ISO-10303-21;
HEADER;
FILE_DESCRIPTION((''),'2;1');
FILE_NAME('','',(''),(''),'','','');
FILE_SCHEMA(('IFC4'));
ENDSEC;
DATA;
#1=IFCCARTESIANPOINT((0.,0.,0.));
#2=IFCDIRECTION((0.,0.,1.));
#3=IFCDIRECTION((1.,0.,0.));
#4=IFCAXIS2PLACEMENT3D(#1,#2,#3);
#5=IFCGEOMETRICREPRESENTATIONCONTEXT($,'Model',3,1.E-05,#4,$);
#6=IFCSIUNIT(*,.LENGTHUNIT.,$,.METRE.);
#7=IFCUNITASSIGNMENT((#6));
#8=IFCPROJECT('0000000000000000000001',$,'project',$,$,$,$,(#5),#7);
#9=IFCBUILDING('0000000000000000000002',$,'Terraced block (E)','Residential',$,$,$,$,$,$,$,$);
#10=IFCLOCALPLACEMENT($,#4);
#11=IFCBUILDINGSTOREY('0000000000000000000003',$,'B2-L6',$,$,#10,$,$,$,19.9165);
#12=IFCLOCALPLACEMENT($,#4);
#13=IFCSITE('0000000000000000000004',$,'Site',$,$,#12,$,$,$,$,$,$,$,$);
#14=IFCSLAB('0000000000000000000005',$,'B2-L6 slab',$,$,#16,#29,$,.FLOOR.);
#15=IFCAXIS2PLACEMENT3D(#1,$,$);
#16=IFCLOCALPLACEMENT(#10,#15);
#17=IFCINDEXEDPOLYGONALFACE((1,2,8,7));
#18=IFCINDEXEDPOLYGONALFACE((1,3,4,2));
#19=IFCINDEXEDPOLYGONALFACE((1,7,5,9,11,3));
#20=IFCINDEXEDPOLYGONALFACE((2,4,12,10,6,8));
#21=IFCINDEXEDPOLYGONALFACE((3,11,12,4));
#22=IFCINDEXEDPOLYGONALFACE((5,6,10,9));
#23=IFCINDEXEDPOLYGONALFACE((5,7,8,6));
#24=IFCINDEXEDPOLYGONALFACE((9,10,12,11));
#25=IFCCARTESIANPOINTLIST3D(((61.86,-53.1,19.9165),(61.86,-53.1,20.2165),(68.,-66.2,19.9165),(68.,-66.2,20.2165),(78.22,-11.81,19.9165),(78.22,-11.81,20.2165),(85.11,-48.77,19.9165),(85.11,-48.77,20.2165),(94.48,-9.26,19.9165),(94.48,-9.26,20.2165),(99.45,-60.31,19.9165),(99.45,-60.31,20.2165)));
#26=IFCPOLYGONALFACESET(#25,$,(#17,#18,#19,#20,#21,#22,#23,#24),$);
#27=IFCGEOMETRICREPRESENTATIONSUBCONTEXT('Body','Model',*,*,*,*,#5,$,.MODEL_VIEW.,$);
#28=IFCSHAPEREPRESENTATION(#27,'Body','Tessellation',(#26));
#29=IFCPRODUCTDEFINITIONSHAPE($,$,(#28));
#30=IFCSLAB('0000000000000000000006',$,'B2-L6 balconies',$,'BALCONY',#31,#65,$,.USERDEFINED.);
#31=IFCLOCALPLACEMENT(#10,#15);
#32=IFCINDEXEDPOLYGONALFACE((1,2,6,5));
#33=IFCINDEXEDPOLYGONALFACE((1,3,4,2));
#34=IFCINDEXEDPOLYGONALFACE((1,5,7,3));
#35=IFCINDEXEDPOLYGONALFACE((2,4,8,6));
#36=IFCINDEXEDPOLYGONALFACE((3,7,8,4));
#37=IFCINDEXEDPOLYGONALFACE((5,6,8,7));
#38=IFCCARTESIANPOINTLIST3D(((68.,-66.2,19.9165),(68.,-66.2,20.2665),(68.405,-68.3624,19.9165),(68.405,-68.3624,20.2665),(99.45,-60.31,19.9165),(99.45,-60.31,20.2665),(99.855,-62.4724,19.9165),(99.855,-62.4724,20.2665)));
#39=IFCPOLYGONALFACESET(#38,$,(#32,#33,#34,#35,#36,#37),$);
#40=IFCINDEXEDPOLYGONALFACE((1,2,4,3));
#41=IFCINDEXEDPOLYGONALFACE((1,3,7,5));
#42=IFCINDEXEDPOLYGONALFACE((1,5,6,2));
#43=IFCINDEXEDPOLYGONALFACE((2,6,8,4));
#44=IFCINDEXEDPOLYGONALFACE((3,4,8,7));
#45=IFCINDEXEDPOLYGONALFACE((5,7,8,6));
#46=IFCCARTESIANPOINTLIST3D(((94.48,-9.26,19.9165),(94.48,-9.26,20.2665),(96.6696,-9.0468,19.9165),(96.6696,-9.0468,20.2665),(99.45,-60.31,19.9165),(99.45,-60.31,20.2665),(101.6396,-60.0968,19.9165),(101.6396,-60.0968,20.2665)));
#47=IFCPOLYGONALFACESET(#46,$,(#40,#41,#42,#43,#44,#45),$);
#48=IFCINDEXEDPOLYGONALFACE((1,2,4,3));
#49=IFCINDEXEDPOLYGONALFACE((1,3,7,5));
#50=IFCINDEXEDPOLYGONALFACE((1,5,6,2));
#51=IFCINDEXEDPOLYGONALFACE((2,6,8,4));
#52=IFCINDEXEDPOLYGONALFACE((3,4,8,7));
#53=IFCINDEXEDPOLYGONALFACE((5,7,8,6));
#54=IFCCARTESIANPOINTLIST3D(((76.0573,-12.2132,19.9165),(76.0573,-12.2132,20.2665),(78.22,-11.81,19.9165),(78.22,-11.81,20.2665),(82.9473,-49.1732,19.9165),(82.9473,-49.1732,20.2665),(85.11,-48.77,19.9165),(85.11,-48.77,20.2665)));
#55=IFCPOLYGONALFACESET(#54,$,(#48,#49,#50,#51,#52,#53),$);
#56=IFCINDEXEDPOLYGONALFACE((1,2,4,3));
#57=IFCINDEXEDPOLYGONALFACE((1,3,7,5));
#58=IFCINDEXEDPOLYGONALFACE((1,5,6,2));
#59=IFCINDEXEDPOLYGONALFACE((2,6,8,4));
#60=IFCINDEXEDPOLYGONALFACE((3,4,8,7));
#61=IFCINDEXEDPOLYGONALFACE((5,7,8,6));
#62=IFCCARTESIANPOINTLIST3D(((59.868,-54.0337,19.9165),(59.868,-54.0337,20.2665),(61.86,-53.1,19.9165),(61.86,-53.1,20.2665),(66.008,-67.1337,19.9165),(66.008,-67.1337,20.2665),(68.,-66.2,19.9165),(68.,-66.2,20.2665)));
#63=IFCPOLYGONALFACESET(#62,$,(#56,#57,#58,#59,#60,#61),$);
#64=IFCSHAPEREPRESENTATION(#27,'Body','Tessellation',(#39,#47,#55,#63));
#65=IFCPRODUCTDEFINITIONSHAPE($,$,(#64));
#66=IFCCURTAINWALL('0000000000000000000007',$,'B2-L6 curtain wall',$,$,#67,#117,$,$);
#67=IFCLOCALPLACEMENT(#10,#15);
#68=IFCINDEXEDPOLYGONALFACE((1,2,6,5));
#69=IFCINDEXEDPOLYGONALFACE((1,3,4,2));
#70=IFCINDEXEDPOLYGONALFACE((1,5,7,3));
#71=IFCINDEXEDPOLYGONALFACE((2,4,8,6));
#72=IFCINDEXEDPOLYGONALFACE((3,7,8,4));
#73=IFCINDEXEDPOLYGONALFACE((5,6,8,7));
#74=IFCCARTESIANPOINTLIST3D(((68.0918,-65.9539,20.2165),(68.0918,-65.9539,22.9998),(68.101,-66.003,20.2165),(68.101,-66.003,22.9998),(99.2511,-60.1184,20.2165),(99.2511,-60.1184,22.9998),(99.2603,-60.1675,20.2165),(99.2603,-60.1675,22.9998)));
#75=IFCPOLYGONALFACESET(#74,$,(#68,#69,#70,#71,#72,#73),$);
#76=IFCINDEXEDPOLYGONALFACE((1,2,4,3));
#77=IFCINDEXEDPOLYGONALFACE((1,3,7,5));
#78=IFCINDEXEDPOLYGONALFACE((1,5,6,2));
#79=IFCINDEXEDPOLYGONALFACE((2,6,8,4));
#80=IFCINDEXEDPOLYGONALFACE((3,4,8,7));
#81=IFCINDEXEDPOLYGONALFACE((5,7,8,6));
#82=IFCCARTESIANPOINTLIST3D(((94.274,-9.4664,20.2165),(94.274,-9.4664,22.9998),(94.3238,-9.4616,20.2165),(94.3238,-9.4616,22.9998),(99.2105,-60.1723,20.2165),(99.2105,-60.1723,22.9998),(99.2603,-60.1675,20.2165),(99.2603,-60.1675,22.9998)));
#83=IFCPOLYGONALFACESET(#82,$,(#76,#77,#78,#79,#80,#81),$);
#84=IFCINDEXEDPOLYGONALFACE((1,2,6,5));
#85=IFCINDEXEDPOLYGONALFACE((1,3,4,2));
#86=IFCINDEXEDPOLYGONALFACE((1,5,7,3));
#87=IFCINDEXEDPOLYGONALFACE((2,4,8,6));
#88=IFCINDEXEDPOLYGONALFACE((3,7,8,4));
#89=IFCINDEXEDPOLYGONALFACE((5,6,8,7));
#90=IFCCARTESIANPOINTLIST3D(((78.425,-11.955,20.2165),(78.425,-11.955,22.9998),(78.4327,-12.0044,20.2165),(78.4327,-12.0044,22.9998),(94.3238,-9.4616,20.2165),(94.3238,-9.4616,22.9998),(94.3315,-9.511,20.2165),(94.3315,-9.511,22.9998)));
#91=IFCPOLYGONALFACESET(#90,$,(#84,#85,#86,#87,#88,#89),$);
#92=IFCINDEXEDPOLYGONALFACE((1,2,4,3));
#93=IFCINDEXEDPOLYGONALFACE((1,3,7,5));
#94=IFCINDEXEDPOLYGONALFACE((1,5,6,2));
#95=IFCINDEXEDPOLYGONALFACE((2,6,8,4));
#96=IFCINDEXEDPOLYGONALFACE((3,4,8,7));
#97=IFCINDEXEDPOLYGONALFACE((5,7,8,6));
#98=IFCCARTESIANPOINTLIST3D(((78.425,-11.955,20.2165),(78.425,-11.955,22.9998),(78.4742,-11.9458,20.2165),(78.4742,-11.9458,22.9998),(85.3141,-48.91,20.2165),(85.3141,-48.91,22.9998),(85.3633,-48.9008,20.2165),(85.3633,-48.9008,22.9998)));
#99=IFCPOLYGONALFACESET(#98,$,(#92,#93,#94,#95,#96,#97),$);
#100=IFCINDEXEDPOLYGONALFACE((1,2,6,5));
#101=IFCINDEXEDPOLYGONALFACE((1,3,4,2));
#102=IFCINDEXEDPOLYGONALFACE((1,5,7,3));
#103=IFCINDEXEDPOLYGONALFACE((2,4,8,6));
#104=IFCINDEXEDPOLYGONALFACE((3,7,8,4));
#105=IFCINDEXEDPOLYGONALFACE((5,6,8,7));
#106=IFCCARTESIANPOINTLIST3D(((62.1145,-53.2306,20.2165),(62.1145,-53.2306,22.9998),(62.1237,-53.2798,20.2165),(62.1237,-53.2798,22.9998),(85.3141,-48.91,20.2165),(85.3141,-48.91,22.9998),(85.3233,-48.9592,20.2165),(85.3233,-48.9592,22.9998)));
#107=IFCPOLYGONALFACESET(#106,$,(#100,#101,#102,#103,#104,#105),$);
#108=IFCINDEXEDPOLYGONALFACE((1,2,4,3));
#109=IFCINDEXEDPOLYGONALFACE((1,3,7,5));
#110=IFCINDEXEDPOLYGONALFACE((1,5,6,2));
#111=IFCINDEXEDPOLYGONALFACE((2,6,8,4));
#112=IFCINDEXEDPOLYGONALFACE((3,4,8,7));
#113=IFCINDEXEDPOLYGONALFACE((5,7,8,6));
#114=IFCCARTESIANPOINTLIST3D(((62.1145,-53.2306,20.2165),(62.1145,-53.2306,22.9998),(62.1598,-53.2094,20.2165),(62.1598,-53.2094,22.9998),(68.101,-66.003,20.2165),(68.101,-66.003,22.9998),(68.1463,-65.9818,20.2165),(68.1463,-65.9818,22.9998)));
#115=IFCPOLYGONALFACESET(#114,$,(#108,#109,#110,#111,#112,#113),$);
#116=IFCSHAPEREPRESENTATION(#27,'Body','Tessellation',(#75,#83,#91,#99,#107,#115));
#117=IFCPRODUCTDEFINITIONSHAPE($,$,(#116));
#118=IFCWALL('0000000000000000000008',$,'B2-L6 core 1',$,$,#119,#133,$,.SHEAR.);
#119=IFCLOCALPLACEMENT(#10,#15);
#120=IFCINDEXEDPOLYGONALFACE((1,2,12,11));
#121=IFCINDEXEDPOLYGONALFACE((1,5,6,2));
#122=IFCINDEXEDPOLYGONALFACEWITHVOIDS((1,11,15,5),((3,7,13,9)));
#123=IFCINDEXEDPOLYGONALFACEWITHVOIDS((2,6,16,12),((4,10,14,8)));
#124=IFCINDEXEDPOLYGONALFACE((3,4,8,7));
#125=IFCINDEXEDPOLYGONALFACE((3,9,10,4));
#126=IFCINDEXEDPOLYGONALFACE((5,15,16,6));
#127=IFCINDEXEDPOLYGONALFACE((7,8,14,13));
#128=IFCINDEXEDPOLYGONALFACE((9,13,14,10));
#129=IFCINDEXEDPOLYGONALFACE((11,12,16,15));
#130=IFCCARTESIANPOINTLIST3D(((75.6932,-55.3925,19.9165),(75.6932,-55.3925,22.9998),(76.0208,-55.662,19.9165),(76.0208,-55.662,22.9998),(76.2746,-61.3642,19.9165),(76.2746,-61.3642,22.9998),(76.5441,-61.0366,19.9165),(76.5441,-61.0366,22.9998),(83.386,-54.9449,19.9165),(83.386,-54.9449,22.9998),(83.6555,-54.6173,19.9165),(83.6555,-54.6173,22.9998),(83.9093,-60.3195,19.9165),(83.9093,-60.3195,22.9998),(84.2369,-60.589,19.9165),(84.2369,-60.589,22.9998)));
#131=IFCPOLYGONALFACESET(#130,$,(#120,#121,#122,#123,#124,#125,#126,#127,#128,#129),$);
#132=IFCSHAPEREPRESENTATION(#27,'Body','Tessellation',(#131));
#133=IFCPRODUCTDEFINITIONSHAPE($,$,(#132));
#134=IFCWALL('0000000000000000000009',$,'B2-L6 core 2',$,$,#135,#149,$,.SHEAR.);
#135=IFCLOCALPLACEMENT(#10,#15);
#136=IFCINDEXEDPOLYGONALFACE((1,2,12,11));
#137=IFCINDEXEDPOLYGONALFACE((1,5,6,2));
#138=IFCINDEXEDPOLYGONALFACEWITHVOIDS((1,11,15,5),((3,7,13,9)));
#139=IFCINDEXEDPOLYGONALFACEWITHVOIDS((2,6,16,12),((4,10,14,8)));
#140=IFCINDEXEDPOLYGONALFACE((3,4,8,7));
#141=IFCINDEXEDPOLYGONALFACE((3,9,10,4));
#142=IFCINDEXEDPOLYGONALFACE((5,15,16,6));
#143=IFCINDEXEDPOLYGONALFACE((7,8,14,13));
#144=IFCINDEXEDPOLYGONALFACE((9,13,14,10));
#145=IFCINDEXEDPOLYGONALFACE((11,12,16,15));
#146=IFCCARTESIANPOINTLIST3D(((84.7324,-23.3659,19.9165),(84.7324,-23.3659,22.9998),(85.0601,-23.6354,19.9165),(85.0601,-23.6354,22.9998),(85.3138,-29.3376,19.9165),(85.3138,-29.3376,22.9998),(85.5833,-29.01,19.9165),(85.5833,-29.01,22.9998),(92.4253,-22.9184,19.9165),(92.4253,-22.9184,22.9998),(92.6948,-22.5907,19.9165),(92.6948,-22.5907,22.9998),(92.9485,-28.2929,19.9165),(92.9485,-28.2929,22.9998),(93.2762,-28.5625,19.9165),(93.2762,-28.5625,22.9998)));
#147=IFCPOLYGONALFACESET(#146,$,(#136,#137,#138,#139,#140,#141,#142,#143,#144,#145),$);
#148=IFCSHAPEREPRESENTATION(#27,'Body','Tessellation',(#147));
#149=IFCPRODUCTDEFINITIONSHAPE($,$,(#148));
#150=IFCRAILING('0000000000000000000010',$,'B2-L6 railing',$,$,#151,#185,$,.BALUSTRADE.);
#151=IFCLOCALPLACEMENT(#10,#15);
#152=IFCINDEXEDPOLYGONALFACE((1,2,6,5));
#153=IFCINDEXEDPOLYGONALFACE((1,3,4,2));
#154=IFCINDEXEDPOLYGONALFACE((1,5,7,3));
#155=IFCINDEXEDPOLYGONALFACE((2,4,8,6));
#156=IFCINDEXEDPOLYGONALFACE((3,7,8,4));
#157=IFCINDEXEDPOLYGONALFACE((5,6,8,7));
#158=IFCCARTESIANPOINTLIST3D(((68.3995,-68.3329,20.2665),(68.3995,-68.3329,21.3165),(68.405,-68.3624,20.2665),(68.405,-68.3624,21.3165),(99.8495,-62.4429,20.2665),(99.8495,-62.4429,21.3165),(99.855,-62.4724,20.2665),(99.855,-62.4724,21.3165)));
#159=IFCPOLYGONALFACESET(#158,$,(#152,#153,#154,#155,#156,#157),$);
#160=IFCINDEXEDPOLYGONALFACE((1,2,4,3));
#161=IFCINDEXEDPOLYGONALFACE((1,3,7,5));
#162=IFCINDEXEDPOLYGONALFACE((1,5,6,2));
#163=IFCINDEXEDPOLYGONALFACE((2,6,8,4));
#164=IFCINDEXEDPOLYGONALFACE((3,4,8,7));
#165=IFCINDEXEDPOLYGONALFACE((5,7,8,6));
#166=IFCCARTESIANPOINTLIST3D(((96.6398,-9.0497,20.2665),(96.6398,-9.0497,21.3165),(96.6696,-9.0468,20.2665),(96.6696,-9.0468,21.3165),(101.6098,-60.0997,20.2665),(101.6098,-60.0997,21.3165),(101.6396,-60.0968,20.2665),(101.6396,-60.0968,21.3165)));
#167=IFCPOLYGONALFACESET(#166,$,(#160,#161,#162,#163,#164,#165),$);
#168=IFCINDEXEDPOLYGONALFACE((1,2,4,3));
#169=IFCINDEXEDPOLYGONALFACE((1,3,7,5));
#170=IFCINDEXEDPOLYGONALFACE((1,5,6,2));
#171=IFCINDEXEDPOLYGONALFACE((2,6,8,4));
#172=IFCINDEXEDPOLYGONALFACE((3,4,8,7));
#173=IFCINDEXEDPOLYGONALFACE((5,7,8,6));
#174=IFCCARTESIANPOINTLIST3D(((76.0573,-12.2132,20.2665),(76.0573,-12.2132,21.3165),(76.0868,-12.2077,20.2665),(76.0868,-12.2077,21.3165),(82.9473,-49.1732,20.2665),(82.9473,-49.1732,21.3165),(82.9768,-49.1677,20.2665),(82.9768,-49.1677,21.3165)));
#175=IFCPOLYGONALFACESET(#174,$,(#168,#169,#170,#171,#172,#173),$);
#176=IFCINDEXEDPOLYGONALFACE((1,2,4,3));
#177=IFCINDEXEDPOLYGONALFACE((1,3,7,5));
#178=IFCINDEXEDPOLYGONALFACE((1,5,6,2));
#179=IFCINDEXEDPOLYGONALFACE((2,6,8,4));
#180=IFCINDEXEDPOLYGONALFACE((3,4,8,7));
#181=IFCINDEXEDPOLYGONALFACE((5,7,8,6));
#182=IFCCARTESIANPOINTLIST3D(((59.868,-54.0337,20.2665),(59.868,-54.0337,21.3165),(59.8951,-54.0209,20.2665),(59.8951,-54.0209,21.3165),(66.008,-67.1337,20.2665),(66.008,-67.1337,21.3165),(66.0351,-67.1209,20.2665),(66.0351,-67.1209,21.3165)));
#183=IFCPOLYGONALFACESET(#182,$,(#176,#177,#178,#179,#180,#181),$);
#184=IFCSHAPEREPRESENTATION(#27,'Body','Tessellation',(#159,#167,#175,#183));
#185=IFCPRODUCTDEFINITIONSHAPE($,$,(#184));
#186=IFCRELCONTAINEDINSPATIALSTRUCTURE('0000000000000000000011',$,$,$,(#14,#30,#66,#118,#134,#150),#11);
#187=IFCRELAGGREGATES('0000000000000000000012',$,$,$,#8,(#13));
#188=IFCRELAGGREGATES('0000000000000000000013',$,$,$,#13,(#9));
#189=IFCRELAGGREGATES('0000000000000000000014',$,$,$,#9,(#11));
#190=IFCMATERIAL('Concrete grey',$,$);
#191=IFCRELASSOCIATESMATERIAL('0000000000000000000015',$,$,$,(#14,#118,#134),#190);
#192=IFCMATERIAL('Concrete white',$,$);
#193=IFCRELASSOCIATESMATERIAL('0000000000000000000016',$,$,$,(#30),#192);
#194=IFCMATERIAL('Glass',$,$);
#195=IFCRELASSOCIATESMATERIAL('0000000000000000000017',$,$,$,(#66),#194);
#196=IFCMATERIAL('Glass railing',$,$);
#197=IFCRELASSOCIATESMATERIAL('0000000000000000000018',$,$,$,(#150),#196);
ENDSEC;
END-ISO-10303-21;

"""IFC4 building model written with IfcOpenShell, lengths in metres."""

from ifc_helpers import new_model, si_unit, frame, origin_with_axes, place, context, subcontext, project, spatial, polyline, outline, extrude, material, element, save


model = new_model("IFC4")

# Units and contexts
model_context = context("Model", 3, precision=1e-05, world=origin_with_axes())
body_context = subcontext(model_context, "Body", "Model", "MODEL_VIEW")
ifc_project = project(units=[si_unit("LENGTHUNIT", "METRE")], contexts=[model_context])

# Site, building, storey
site_placement = place(None, origin_with_axes())
site = spatial("IfcSite", under=ifc_project, at=site_placement, Name="Site")
building = spatial("IfcBuilding", under=site, Name="Terraced block (E)", Description="Residential")
storey_placement = place(None, origin_with_axes())
storey = spatial("IfcBuildingStorey", under=building, at=storey_placement, Name="B2-L6", Elevation=19.9165)

# Slabs
ifc_material_1 = material(Name="Concrete grey")
slab_1_placement = place(storey_placement, origin_with_axes())
element("IfcSlab", 1, at=slab_1_placement, inside=storey, material=ifc_material_1, Name="B2-L6 slab", PredefinedType="FLOOR", context=body_context, shape_type="SweptSolid", body=[
    extrude(outline(polyline([(68.0, -66.2), (99.45, -60.31), (94.48, -9.26), (78.22, -11.81), (85.11, -48.77), (61.86, -53.1), (68.0, -66.2)])), frame((0.0, 0.0, 19.9165), z_axis=(0.0, 0.0, 1.0), x_axis=(1.0, 0.0, 0.0)), (0.0, 0.0, 1.0), 0.3),
])
ifc_material_2 = material(Name="Concrete white")
slab_2_placement = place(storey_placement, origin_with_axes())
element("IfcSlab", 2, at=slab_2_placement, inside=storey, material=ifc_material_2, Name="B2-L6 balconies", ObjectType="BALCONY", PredefinedType="USERDEFINED", context=body_context, shape_type="SweptSolid", body=[
    extrude(outline(polyline([(68.0, -66.2), (99.45, -60.31), (99.855, -62.4724), (68.405, -68.3624), (68.0, -66.2)])), frame((0.0, 0.0, 19.9165), z_axis=(0.0, 0.0, 1.0), x_axis=(1.0, 0.0, 0.0)), (0.0, 0.0, 1.0), 0.35),
    extrude(outline(polyline([(99.45, -60.31), (94.48, -9.26), (96.6696, -9.0468), (101.6396, -60.0968), (99.45, -60.31)])), frame((0.0, 0.0, 19.9165), z_axis=(0.0, 0.0, 1.0), x_axis=(1.0, 0.0, 0.0)), (0.0, 0.0, 1.0), 0.35),
    extrude(outline(polyline([(78.22, -11.81), (85.11, -48.77), (82.9473, -49.1732), (76.0573, -12.2132), (78.22, -11.81)])), frame((0.0, 0.0, 19.9165), z_axis=(0.0, 0.0, 1.0), x_axis=(1.0, 0.0, 0.0)), (0.0, 0.0, 1.0), 0.35),
    extrude(outline(polyline([(61.86, -53.1), (68.0, -66.2), (66.008, -67.1337), (59.868, -54.0337), (61.86, -53.1)])), frame((0.0, 0.0, 19.9165), z_axis=(0.0, 0.0, 1.0), x_axis=(1.0, 0.0, 0.0)), (0.0, 0.0, 1.0), 0.35),
])

# Curtain wall
ifc_material_3 = material(Name="Glass")
curtain_wall_placement = place(storey_placement, origin_with_axes())
element("IfcCurtainWall", 3, at=curtain_wall_placement, inside=storey, material=ifc_material_3, Name="B2-L6 curtain wall", context=body_context, shape_type="SweptSolid", body=[
    extrude(outline(polyline([(68.101, -66.003), (99.2603, -60.1675), (99.2511, -60.1184), (68.0918, -65.9539), (68.101, -66.003)])), frame((0.0, 0.0, 20.2165), z_axis=(0.0, 0.0, 1.0), x_axis=(1.0, 0.0, 0.0)), (0.0, 0.0, 1.0), 2.7833),
    extrude(outline(polyline([(99.2603, -60.1675), (94.3238, -9.4616), (94.274, -9.4664), (99.2105, -60.1723), (99.2603, -60.1675)])), frame((0.0, 0.0, 20.2165), z_axis=(0.0, 0.0, 1.0), x_axis=(1.0, 0.0, 0.0)), (0.0, 0.0, 1.0), 2.7833),
    extrude(outline(polyline([(94.3238, -9.4616), (78.425, -11.955), (78.4327, -12.0044), (94.3315, -9.511), (94.3238, -9.4616)])), frame((0.0, 0.0, 20.2165), z_axis=(0.0, 0.0, 1.0), x_axis=(1.0, 0.0, 0.0)), (0.0, 0.0, 1.0), 2.7833),
    extrude(outline(polyline([(78.425, -11.955), (85.3141, -48.91), (85.3633, -48.9008), (78.4742, -11.9458), (78.425, -11.955)])), frame((0.0, 0.0, 20.2165), z_axis=(0.0, 0.0, 1.0), x_axis=(1.0, 0.0, 0.0)), (0.0, 0.0, 1.0), 2.7833),
    extrude(outline(polyline([(85.3141, -48.91), (62.1145, -53.2306), (62.1237, -53.2798), (85.3233, -48.9592), (85.3141, -48.91)])), frame((0.0, 0.0, 20.2165), z_axis=(0.0, 0.0, 1.0), x_axis=(1.0, 0.0, 0.0)), (0.0, 0.0, 1.0), 2.7833),
    extrude(outline(polyline([(62.1145, -53.2306), (68.101, -66.003), (68.1463, -65.9818), (62.1598, -53.2094), (62.1145, -53.2306)])), frame((0.0, 0.0, 20.2165), z_axis=(0.0, 0.0, 1.0), x_axis=(1.0, 0.0, 0.0)), (0.0, 0.0, 1.0), 2.7833),
])

# Walls
wall_1_placement = place(storey_placement, origin_with_axes())
element("IfcWall", 4, at=wall_1_placement, inside=storey, material=ifc_material_1, Name="B2-L6 core 1", PredefinedType="SHEAR", context=body_context, shape_type="SweptSolid", body=[
    extrude(outline(polyline([(84.2369, -60.589), (83.6555, -54.6173), (75.6932, -55.3925), (76.2746, -61.3642), (84.2369, -60.589)]), holes=[polyline([(83.9093, -60.3195), (83.386, -54.9449), (76.0208, -55.662), (76.5441, -61.0366), (83.9093, -60.3195)])]), frame((0.0, 0.0, 19.9165), z_axis=(0.0, 0.0, 1.0), x_axis=(1.0, 0.0, 0.0)), (0.0, 0.0, 1.0), 3.0833),
])
wall_2_placement = place(storey_placement, origin_with_axes())
element("IfcWall", 5, at=wall_2_placement, inside=storey, material=ifc_material_1, Name="B2-L6 core 2", PredefinedType="SHEAR", context=body_context, shape_type="SweptSolid", body=[
    extrude(outline(polyline([(93.2762, -28.5625), (92.6948, -22.5907), (84.7324, -23.3659), (85.3138, -29.3376), (93.2762, -28.5625)]), holes=[polyline([(92.9485, -28.2929), (92.4253, -22.9184), (85.0601, -23.6354), (85.5833, -29.01), (92.9485, -28.2929)])]), frame((0.0, 0.0, 19.9165), z_axis=(0.0, 0.0, 1.0), x_axis=(1.0, 0.0, 0.0)), (0.0, 0.0, 1.0), 3.0833),
])

# Railing
ifc_material_4 = material(Name="Glass railing")
railing_placement = place(storey_placement, origin_with_axes())
element("IfcRailing", 6, at=railing_placement, inside=storey, material=ifc_material_4, Name="B2-L6 railing", PredefinedType="BALUSTRADE", context=body_context, shape_type="SweptSolid", body=[
    extrude(outline(polyline([(68.405, -68.3624), (99.855, -62.4724), (99.8495, -62.4429), (68.3995, -68.3329), (68.405, -68.3624)])), frame((0.0, 0.0, 20.2665), z_axis=(0.0, 0.0, 1.0), x_axis=(1.0, 0.0, 0.0)), (0.0, 0.0, 1.0), 1.05),
    extrude(outline(polyline([(101.6396, -60.0968), (96.6696, -9.0468), (96.6398, -9.0497), (101.6098, -60.0997), (101.6396, -60.0968)])), frame((0.0, 0.0, 20.2665), z_axis=(0.0, 0.0, 1.0), x_axis=(1.0, 0.0, 0.0)), (0.0, 0.0, 1.0), 1.05),
    extrude(outline(polyline([(76.0573, -12.2132), (82.9473, -49.1732), (82.9768, -49.1677), (76.0868, -12.2077), (76.0573, -12.2132)])), frame((0.0, 0.0, 20.2665), z_axis=(0.0, 0.0, 1.0), x_axis=(1.0, 0.0, 0.0)), (0.0, 0.0, 1.0), 1.05),
    extrude(outline(polyline([(59.868, -54.0337), (66.008, -67.1337), (66.0351, -67.1209), (59.8951, -54.0209), (59.868, -54.0337)])), frame((0.0, 0.0, 20.2665), z_axis=(0.0, 0.0, 1.0), x_axis=(1.0, 0.0, 0.0)), (0.0, 0.0, 1.0), 1.05),
])

save(model, "model.ifc")
